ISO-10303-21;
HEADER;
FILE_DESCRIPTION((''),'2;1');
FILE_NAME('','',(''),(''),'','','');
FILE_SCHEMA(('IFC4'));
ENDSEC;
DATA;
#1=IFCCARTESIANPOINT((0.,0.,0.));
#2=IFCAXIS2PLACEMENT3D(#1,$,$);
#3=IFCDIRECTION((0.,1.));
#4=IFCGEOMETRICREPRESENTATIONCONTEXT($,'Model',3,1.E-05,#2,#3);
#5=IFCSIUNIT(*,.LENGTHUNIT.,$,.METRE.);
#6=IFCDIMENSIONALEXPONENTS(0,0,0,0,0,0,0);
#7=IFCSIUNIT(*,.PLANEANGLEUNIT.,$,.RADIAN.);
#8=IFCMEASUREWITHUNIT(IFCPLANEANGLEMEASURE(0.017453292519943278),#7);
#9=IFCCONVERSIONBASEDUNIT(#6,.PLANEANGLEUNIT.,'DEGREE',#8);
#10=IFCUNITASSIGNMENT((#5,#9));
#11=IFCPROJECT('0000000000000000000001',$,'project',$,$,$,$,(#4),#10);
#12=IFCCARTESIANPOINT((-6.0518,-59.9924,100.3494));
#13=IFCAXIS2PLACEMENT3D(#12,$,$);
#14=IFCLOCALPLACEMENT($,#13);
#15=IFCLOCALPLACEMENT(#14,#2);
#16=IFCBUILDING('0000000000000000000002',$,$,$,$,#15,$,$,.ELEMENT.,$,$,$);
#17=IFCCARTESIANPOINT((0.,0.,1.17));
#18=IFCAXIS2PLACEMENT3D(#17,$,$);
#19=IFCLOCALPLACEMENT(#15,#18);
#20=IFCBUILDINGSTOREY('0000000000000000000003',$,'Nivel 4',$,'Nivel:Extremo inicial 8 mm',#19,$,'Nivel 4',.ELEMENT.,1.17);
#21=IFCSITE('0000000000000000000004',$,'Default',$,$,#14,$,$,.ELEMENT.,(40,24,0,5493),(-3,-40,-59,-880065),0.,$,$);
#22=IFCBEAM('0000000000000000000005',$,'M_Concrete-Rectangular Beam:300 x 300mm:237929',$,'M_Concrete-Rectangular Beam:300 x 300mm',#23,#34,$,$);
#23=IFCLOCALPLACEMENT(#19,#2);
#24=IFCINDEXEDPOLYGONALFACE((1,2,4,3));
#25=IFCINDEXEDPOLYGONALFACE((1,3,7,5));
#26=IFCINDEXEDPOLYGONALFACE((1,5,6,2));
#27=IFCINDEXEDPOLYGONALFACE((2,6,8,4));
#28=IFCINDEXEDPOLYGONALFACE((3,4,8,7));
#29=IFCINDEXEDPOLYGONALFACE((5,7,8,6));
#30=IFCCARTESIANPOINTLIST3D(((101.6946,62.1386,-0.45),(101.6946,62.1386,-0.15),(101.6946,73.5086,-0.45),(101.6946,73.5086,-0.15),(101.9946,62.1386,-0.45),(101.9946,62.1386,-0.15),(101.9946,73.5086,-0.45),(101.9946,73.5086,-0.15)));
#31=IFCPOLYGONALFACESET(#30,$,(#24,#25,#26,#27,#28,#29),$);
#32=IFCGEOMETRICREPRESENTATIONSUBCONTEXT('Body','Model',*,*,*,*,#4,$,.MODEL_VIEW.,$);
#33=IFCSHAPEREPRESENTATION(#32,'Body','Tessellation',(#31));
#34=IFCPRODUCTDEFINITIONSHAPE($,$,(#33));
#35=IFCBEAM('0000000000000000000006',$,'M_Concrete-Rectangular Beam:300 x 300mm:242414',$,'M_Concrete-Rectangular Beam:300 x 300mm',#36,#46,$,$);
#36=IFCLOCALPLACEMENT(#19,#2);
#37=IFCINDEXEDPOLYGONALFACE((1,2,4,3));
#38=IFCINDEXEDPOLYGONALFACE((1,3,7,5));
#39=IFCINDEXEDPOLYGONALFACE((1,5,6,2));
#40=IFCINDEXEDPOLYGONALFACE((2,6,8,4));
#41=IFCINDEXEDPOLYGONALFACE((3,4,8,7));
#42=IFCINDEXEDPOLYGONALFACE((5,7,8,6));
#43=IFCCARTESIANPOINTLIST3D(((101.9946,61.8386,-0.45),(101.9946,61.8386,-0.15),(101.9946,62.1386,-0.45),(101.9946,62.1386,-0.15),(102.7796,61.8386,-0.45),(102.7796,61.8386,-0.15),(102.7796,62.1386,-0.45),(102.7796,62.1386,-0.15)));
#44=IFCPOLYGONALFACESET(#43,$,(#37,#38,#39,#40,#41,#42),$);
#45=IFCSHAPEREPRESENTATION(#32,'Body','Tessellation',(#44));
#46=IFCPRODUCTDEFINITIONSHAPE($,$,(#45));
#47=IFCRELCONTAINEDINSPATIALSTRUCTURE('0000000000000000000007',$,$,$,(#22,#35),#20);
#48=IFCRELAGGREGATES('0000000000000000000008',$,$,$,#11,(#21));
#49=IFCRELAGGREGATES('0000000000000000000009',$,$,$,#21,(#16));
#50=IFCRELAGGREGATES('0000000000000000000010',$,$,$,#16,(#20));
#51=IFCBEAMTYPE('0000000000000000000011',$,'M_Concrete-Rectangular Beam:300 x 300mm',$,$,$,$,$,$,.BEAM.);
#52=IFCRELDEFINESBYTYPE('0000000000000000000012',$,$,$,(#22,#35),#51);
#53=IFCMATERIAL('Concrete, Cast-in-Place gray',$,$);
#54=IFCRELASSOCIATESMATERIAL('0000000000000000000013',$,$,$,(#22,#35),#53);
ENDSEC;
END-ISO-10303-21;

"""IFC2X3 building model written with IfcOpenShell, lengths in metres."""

from ifc_helpers import new_model, entity, si_unit, converted_unit, direction, frame, frame_2d, origin, place, context, subcontext, project, spatial, rectangle, extrude, material, type_object, element, save


model = new_model("IFC2X3")

# Units and contexts
model_context = context("Model", 3, precision=1e-05, world=origin(), true_north=direction((0.0, 1.0)))
body_context = subcontext(model_context, "Body", "Model", "MODEL_VIEW")
ifc_project = project(units=[si_unit("LENGTHUNIT", "METRE"), converted_unit("PLANEANGLEUNIT", "DEGREE", entity("IfcPlaneAngleMeasure", 0.017453292519943278), si_unit("PLANEANGLEUNIT", "RADIAN"), dimensions=[0, 0, 0, 0, 0, 0, 0])], contexts=[model_context])

# Site, building, storey
site_placement = place(None, frame((-6.0518, -59.9924, 100.3494)))
site = spatial("IfcSite", under=ifc_project, at=site_placement, Name="Default", CompositionType="ELEMENT", RefLatitude=(40, 24, 0, 5493), RefLongitude=(-3, -40, -59, -880065), RefElevation=0.0)
building_placement = place(site_placement, origin())
building = spatial("IfcBuilding", under=site, at=building_placement, CompositionType="ELEMENT")
storey_placement = place(building_placement, frame((0.0, 0.0, 1.17)))
storey = spatial("IfcBuildingStorey", under=building, at=storey_placement, Name="Nivel 4", ObjectType="Nivel:Extremo inicial 8 mm", LongName="Nivel 4", CompositionType="ELEMENT", Elevation=1.17)

# Beams
ifc_material_1 = material(Name="Concrete, Cast-in-Place gray")
beam_type = type_object("IfcBeamType", Name="M_Concrete-Rectangular Beam:300 x 300mm", PredefinedType="BEAM")
beam_1_placement = place(storey_placement, frame((101.8446, 61.9886, 0.0), z_axis=(0.0, 0.0, 1.0), x_axis=(0.0, 1.0, 0.0)))
element("IfcBeam", 1, at=beam_1_placement, inside=storey, type_object=beam_type, material=ifc_material_1, Name="M_Concrete-Rectangular Beam:300 x 300mm:237929", ObjectType="M_Concrete-Rectangular Beam:300 x 300mm", context=body_context, shape_type="SweptSolid", body=[
    extrude(rectangle(XDim=0.3, YDim=0.3, at=frame_2d((0.0, 0.0), x_axis=(1.0, 0.0))), frame((0.15, 0.0, -0.3), z_axis=(1.0, 0.0, 0.0), x_axis=(0.0, 0.0, -1.0)), (0.0, 0.0, 1.0), 11.37),
])
beam_2_placement = place(storey_placement, frame((101.8446, 61.9886, 0.0)))
element("IfcBeam", 2, at=beam_2_placement, inside=storey, type_object=beam_type, material=ifc_material_1, Name="M_Concrete-Rectangular Beam:300 x 300mm:242414", ObjectType="M_Concrete-Rectangular Beam:300 x 300mm", context=body_context, shape_type="SweptSolid", body=[
    extrude(rectangle(XDim=0.3, YDim=0.3, at=frame_2d((0.0, 0.0), x_axis=(1.0, 0.0))), frame((0.15, 0.0, -0.3), z_axis=(1.0, 0.0, 0.0), x_axis=(0.0, 0.0, -1.0)), (0.0, 0.0, 1.0), 0.785),
])

save(model, "model.ifc")
